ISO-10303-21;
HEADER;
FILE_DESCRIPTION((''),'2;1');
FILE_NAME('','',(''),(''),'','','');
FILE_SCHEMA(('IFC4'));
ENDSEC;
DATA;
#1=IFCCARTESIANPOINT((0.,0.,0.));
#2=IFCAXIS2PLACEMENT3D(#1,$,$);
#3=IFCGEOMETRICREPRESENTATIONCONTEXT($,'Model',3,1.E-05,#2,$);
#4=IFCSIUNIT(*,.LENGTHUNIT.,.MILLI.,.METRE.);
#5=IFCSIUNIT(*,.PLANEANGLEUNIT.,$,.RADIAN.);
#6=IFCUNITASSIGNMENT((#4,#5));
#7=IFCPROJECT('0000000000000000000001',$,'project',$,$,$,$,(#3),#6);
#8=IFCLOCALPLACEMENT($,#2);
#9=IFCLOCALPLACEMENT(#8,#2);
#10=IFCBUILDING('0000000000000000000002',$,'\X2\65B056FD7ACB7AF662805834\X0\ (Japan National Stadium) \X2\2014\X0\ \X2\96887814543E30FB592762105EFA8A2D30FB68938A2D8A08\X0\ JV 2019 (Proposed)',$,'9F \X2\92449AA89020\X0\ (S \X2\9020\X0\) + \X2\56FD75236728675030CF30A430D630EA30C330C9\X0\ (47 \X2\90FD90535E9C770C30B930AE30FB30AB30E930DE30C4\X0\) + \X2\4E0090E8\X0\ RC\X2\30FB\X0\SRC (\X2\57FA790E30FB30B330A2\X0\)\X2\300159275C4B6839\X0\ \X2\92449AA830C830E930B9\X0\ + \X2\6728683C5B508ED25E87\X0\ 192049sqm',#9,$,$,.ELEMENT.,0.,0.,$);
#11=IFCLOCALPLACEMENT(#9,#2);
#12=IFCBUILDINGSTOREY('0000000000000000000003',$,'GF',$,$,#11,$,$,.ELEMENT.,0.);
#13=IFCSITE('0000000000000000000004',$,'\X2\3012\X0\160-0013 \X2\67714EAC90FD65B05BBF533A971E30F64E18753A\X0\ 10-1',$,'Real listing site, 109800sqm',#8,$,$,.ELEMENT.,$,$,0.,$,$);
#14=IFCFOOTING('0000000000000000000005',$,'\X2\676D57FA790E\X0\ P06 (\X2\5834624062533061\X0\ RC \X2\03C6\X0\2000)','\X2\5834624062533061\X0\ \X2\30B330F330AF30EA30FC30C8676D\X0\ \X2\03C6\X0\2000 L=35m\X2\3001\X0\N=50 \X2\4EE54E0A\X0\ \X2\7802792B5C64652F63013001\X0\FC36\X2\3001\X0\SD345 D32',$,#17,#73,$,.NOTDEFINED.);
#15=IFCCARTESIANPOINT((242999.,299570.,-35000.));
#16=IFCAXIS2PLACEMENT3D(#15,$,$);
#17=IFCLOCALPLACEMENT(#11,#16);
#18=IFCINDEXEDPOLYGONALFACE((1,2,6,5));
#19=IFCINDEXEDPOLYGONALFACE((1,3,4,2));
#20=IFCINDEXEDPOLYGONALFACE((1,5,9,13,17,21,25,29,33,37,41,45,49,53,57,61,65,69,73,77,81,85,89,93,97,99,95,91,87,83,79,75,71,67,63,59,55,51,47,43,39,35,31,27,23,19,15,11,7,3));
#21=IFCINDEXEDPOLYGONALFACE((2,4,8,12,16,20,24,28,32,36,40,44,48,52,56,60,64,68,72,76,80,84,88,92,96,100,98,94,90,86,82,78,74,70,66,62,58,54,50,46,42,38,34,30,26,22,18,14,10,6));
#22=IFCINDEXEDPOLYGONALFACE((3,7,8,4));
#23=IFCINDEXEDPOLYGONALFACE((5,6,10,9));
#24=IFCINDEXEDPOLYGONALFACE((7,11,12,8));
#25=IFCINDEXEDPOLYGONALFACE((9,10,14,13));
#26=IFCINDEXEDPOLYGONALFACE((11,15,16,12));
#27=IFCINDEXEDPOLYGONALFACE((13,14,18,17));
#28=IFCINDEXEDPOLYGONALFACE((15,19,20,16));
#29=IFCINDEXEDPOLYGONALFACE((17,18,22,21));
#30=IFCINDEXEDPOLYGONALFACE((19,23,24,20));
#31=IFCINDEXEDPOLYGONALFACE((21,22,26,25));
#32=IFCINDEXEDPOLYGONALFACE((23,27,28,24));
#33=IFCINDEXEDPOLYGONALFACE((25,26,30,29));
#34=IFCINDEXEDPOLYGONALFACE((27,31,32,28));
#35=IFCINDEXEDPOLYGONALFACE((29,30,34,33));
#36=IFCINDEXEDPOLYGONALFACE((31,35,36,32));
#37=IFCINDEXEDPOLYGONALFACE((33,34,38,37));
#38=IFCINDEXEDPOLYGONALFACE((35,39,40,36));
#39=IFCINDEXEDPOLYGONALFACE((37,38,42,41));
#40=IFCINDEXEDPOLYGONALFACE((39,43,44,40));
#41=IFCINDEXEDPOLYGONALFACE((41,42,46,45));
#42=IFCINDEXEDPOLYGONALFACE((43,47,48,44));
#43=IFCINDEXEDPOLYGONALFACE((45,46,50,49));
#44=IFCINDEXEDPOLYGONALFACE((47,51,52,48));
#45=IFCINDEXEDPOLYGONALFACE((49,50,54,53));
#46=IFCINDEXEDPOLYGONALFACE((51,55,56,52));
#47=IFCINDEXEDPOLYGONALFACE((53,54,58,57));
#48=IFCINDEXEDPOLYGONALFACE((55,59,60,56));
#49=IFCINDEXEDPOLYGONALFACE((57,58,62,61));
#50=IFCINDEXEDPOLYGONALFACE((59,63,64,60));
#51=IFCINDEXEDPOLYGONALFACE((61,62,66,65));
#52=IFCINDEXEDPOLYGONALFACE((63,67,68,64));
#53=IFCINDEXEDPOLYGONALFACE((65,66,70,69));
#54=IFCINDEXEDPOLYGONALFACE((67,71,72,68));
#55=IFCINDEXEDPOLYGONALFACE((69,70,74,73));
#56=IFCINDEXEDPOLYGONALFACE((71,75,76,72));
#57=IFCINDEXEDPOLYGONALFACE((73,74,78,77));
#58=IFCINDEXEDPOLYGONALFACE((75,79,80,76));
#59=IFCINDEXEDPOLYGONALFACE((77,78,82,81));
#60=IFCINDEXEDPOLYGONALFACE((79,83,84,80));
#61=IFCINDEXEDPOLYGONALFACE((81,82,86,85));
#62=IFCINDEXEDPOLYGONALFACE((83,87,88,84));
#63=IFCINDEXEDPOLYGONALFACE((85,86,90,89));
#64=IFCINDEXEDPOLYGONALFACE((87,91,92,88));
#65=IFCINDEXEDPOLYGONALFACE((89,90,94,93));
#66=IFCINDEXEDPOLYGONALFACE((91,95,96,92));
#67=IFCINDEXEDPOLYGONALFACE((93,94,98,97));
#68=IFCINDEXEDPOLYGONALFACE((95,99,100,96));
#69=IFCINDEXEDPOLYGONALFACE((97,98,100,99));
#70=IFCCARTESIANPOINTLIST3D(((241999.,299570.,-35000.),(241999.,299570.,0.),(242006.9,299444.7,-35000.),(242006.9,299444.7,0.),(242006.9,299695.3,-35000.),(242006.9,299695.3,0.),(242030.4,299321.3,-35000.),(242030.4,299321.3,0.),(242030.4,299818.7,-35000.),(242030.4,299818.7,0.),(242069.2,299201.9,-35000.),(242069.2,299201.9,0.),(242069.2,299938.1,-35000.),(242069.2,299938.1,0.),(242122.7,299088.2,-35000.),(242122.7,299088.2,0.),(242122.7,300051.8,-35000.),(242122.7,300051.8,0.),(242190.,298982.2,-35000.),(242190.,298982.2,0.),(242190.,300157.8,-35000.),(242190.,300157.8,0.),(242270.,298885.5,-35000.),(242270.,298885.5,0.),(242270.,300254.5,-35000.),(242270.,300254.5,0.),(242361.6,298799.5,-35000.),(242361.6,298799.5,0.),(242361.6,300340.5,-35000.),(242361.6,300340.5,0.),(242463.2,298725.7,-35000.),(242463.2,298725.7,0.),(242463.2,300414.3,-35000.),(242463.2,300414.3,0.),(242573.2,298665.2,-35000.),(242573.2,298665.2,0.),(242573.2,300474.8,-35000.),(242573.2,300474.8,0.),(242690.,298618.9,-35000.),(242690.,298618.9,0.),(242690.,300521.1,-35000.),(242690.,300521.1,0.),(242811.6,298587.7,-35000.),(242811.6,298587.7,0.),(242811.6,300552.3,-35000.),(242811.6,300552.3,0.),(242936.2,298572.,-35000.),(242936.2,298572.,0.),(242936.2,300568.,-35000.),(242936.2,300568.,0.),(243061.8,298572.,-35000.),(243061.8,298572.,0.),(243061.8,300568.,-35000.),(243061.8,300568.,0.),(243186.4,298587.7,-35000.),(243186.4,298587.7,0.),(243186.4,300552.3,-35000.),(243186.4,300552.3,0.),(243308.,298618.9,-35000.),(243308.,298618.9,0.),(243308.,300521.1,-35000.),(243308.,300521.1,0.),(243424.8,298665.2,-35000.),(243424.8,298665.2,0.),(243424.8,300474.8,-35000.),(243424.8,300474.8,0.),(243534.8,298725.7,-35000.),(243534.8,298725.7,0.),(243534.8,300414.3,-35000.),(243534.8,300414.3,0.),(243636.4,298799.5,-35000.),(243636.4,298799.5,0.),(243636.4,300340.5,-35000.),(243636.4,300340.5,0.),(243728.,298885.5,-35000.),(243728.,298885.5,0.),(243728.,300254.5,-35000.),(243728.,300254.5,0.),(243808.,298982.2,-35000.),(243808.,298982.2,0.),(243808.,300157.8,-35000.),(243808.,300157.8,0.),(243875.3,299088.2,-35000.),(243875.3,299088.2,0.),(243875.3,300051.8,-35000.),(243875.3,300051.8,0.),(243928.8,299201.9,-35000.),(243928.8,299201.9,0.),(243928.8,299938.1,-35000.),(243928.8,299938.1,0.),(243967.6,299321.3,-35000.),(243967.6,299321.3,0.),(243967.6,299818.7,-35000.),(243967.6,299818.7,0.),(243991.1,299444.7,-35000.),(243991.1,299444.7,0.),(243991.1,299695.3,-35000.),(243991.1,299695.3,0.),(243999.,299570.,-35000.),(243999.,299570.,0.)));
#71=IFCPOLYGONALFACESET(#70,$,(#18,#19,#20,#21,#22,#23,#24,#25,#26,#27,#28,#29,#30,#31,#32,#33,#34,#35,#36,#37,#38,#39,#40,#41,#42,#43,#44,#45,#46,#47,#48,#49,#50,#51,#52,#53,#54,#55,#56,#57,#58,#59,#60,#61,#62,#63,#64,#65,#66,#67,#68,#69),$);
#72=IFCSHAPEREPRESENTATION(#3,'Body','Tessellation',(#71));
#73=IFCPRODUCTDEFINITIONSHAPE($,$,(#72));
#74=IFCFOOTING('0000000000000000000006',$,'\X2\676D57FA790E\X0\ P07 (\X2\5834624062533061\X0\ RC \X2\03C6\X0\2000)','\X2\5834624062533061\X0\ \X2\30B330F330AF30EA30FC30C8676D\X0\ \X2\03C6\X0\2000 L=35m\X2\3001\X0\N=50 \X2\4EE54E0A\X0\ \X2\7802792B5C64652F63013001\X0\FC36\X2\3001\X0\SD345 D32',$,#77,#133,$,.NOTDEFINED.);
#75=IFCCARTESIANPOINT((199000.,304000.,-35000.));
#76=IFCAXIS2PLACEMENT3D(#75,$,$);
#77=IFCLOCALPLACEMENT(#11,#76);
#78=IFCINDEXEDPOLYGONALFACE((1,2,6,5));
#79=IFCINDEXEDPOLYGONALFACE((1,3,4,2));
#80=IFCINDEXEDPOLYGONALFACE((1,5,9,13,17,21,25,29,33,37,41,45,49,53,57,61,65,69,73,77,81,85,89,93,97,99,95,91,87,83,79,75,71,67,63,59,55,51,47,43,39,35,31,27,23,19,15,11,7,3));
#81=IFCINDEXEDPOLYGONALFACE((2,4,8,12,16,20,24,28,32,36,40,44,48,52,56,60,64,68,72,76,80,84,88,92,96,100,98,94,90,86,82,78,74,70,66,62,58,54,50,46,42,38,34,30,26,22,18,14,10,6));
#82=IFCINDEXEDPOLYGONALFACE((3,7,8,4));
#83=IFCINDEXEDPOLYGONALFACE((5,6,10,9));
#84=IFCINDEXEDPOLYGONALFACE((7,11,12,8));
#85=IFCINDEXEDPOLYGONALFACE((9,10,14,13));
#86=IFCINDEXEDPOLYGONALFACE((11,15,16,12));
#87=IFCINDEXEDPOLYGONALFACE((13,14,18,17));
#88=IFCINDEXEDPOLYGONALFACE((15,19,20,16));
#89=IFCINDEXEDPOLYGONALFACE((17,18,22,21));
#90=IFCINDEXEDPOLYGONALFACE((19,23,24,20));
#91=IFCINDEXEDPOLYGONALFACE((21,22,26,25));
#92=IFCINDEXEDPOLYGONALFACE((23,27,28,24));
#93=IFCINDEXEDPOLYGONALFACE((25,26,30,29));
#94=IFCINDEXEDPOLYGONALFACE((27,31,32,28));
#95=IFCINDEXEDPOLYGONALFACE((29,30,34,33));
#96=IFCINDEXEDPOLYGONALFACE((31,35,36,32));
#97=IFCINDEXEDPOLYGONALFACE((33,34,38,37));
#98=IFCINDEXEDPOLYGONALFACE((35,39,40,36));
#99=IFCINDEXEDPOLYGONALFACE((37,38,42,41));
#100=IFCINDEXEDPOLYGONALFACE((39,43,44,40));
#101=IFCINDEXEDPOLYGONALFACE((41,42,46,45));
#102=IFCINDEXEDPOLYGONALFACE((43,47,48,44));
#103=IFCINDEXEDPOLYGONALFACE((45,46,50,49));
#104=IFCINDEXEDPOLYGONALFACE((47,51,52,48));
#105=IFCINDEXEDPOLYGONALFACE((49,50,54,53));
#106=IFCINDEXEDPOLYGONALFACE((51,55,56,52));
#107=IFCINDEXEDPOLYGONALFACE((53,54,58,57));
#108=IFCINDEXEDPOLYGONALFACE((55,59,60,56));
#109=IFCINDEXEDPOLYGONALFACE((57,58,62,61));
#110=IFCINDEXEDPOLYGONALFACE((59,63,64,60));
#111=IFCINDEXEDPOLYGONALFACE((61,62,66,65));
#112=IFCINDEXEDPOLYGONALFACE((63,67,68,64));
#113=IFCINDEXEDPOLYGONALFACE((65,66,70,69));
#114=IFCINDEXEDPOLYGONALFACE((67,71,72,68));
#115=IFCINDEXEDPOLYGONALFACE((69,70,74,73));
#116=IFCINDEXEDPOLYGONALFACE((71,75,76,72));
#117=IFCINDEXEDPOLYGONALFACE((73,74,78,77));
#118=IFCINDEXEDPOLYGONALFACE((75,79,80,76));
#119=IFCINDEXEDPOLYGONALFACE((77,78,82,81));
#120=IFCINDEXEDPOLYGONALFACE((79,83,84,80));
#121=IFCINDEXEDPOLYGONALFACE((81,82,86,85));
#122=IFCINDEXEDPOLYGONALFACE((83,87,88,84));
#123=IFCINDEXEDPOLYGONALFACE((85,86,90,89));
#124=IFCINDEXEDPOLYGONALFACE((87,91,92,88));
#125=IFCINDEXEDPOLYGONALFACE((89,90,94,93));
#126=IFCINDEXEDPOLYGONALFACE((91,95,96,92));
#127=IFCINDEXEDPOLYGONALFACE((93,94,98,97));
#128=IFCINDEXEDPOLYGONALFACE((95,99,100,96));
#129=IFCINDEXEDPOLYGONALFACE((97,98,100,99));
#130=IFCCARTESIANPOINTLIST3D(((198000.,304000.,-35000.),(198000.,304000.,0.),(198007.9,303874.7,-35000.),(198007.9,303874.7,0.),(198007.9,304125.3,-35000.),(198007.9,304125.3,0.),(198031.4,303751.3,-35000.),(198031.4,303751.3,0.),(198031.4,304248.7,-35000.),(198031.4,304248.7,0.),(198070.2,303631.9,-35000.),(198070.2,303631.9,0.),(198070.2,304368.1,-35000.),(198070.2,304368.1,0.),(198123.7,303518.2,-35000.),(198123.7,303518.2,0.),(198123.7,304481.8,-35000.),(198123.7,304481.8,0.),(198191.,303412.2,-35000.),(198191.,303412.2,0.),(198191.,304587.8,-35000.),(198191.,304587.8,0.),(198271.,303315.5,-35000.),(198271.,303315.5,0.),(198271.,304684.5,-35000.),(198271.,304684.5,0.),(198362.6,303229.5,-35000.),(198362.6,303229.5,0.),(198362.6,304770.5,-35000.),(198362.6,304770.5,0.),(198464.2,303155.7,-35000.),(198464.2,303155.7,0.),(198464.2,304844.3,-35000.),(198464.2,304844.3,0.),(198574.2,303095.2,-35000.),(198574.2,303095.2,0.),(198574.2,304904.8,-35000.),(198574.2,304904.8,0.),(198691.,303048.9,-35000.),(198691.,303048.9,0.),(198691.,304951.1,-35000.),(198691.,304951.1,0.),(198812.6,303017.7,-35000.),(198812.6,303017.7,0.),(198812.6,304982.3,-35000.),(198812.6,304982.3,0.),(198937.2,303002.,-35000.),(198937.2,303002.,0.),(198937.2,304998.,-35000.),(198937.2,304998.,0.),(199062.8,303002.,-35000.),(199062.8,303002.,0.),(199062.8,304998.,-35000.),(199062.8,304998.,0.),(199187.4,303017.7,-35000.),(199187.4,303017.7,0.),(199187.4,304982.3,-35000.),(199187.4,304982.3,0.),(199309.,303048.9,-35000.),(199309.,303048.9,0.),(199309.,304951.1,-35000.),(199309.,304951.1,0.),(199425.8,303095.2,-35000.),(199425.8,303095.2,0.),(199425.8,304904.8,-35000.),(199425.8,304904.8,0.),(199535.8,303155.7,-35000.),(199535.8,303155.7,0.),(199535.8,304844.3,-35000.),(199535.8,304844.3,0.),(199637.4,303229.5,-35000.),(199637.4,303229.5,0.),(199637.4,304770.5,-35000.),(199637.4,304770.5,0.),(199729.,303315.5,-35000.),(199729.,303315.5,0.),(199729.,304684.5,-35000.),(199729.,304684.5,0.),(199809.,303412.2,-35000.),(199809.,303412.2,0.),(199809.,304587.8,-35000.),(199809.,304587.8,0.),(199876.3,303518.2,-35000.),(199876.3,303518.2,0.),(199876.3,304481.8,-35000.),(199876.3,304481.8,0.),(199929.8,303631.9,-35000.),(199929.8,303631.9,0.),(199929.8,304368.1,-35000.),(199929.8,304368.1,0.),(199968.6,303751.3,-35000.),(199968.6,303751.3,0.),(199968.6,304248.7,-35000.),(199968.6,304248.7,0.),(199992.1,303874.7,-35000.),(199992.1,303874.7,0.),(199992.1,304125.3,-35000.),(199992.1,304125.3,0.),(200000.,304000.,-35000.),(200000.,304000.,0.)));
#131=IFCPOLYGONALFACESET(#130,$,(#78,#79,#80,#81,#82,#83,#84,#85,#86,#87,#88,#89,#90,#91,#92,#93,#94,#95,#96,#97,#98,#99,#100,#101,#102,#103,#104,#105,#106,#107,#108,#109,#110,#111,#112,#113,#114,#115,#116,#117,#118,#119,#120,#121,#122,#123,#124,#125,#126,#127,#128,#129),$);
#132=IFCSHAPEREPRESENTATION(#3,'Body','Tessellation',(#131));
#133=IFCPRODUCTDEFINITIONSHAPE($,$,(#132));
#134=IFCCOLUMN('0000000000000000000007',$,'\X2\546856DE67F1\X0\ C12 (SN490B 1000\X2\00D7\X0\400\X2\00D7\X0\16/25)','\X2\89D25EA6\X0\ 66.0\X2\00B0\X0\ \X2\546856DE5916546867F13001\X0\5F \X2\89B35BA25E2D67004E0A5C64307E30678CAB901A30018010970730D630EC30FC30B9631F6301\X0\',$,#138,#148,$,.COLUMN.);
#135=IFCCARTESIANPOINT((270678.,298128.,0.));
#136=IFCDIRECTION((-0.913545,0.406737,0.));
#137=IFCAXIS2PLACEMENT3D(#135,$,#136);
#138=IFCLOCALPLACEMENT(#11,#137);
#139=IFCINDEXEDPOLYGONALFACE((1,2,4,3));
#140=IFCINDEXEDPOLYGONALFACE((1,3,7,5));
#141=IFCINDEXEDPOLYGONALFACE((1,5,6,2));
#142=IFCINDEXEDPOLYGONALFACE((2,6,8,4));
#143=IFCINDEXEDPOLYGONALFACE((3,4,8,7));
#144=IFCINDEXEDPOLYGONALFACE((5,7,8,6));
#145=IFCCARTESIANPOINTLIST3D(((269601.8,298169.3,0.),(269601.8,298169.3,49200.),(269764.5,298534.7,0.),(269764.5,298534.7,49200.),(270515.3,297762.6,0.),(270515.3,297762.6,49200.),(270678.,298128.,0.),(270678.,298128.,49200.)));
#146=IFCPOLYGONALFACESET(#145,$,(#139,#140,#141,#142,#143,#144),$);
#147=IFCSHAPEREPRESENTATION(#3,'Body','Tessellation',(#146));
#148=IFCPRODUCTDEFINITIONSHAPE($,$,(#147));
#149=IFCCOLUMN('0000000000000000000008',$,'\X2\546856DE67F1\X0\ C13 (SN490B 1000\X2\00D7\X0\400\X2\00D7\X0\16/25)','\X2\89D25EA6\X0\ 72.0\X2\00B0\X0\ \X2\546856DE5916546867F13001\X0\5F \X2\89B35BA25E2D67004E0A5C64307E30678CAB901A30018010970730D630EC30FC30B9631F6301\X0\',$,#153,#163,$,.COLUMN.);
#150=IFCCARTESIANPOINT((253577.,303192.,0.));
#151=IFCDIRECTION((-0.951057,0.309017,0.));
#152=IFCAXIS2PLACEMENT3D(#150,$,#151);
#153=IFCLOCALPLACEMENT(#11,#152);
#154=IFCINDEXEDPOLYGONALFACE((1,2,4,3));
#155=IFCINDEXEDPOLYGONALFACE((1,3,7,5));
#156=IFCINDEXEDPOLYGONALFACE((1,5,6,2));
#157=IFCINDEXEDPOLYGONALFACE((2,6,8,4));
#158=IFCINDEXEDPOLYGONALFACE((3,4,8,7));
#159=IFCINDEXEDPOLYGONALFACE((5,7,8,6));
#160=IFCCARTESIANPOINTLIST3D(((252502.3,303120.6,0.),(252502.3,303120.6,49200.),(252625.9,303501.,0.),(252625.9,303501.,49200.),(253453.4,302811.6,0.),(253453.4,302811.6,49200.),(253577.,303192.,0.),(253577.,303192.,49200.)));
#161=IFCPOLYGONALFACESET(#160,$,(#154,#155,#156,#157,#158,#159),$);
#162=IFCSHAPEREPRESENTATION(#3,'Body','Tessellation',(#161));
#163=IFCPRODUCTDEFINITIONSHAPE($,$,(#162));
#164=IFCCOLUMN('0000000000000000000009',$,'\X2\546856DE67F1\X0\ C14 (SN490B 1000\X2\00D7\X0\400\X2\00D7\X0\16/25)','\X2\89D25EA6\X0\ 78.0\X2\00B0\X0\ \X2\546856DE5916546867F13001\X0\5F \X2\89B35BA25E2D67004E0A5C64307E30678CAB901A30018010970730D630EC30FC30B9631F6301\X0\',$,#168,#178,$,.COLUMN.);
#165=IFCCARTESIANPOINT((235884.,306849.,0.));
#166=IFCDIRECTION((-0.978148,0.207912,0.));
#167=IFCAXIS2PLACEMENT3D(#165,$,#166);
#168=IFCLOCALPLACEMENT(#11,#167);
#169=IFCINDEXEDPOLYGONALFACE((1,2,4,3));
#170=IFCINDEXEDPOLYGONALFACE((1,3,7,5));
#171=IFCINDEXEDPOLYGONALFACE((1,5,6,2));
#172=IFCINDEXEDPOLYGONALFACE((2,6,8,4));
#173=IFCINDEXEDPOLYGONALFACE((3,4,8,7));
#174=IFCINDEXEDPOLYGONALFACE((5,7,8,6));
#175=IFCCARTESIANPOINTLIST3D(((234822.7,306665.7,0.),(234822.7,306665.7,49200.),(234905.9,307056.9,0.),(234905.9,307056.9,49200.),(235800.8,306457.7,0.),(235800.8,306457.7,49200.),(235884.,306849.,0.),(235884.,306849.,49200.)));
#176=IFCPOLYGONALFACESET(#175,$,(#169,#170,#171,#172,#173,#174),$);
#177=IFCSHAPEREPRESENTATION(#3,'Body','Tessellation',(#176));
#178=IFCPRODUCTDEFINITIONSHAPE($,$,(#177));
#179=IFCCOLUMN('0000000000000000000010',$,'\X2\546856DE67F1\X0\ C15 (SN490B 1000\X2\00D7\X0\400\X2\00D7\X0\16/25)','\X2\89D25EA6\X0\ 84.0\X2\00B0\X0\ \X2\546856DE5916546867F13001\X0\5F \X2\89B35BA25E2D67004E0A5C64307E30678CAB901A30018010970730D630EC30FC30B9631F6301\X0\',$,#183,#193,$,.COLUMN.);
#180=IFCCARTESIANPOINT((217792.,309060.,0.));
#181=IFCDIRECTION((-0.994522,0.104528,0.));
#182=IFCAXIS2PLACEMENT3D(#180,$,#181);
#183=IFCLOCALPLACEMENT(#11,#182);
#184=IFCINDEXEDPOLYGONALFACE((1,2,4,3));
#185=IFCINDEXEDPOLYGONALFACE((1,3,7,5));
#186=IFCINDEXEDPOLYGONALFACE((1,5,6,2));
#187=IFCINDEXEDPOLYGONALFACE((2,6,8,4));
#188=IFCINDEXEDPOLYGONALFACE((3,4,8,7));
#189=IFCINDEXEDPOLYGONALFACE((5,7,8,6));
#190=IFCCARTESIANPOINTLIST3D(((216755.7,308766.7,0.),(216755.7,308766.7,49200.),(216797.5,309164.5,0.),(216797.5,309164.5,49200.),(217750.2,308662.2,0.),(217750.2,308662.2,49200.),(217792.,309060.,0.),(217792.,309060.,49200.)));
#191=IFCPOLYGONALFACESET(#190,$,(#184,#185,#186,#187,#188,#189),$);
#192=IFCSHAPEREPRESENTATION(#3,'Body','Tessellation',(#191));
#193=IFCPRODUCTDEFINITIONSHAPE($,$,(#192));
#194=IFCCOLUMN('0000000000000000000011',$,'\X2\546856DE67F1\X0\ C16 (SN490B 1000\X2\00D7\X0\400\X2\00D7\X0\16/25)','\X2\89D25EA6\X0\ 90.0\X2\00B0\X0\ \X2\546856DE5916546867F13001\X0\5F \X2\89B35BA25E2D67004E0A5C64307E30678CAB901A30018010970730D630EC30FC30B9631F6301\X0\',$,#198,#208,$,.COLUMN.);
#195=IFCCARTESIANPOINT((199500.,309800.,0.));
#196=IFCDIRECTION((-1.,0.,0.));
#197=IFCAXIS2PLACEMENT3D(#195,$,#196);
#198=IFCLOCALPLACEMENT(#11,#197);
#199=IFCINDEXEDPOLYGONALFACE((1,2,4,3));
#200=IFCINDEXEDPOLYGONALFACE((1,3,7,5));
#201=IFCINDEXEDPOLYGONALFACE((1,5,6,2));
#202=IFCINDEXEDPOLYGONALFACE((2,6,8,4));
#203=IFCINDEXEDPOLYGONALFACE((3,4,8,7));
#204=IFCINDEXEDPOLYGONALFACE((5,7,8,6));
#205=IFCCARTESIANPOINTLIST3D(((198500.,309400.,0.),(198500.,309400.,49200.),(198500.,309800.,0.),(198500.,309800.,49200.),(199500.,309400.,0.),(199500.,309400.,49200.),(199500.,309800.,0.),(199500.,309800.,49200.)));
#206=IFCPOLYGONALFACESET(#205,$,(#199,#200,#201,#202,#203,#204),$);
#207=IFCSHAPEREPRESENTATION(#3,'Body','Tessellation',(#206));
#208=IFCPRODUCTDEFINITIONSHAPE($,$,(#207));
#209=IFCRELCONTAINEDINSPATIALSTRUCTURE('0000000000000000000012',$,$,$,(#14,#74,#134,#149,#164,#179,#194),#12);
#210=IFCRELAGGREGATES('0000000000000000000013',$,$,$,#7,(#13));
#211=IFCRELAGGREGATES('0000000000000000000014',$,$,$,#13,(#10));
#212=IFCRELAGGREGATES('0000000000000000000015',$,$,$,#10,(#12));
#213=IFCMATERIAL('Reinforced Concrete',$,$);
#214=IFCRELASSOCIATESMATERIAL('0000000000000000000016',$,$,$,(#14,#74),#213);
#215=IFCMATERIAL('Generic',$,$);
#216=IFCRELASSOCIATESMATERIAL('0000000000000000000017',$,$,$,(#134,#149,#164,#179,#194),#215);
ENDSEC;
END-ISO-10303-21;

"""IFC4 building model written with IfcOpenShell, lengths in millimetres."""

from ifc_helpers import new_model, si_unit, frame, frame_2d, origin, origin_2d, place, context, project, spatial, rectangle, circle, extrude, material, element, save


model = new_model("IFC4")

# Units and contexts
model_context = context("Model", 3, precision=1e-05, world=origin())
ifc_project = project(units=[si_unit("LENGTHUNIT", "METRE", prefix="MILLI"), si_unit("PLANEANGLEUNIT", "RADIAN")], contexts=[model_context])

# Site, building, storey
site_placement = place(None, origin())
site = spatial("IfcSite", under=ifc_project, at=site_placement, Name="〒160-0013 東京都新宿区霞ヶ丘町 10-1", ObjectType="Real listing site, 109800sqm", CompositionType="ELEMENT", RefElevation=0.0)
building_placement = place(site_placement, origin())
building = spatial("IfcBuilding", under=site, at=building_placement, Name="新国立競技場 (Japan National Stadium) — 隈研吾・大成建設・梓設計 JV 2019 (Proposed)", ObjectType="9F 鉄骨造 (S 造) + 国産木材ハイブリッド (47 都道府県スギ・カラマツ) + 一部 RC・SRC (基礎・コア)、大屋根 鉄骨トラス + 木格子軒庇 192049sqm", CompositionType="ELEMENT", ElevationOfRefHeight=0.0, ElevationOfTerrain=0.0)
storey_placement = place(building_placement, origin())
storey = spatial("IfcBuildingStorey", under=building, at=storey_placement, Name="GF", CompositionType="ELEMENT", Elevation=0.0)

# Footings
ifc_material_1 = material(Name="Reinforced Concrete")
footing_1_placement = place(storey_placement, frame((242999.0, 299570.0, -35000.0)))
element("IfcFooting", 1, at=footing_1_placement, inside=storey, material=ifc_material_1, Name="杭基礎 P06 (場所打ち RC φ2000)", Description="場所打ち コンクリート杭 φ2000 L=35m、N=50 以上 砂礫層支持、FC36、SD345 D32", PredefinedType="NOTDEFINED", context=model_context, shape_type="SweptSolid", body=[
    extrude(circle(Radius=1000.0, at=origin_2d()), frame((242999.0, 299570.0, -35000.0)), (0.0, 0.0, 1.0), 35000.0),
])
footing_2_placement = place(storey_placement, frame((199000.0, 304000.0, -35000.0)))
element("IfcFooting", 2, at=footing_2_placement, inside=storey, material=ifc_material_1, Name="杭基礎 P07 (場所打ち RC φ2000)", Description="場所打ち コンクリート杭 φ2000 L=35m、N=50 以上 砂礫層支持、FC36、SD345 D32", PredefinedType="NOTDEFINED", context=model_context, shape_type="SweptSolid", body=[
    extrude(circle(Radius=1000.0, at=origin_2d()), frame((199000.0, 304000.0, -35000.0)), (0.0, 0.0, 1.0), 35000.0),
])

# Columns
ifc_material_2 = material(Name="Generic")
column_1_placement = place(storey_placement, frame((270678.0, 298128.0, 0.0), x_axis=(-0.913545, 0.406737, 0.0)))
element("IfcColumn", 3, at=column_1_placement, inside=storey, material=ifc_material_2, Name="周回柱 C12 (SN490B 1000×400×16/25)", Description="角度 66.0° 周回外周柱、5F 観客席最上層まで貫通、耐震ブレース挟持", PredefinedType="COLUMN", context=model_context, shape_type="SweptSolid", body=[
    extrude(rectangle(XDim=1000.0, YDim=400.0, at=frame_2d((500.0, 200.0))), frame((270678.0, 298128.0, 0.0), x_axis=(-0.913545, 0.406737, 0.0)), (0.0, 0.0, 1.0), 49200.0),
])
column_2_placement = place(storey_placement, frame((253577.0, 303192.0, 0.0), x_axis=(-0.951057, 0.309017, 0.0)))
element("IfcColumn", 4, at=column_2_placement, inside=storey, material=ifc_material_2, Name="周回柱 C13 (SN490B 1000×400×16/25)", Description="角度 72.0° 周回外周柱、5F 観客席最上層まで貫通、耐震ブレース挟持", PredefinedType="COLUMN", context=model_context, shape_type="SweptSolid", body=[
    extrude(rectangle(XDim=1000.0, YDim=400.0, at=frame_2d((500.0, 200.0))), frame((253577.0, 303192.0, 0.0), x_axis=(-0.951057, 0.309017, 0.0)), (0.0, 0.0, 1.0), 49200.0),
])
column_3_placement = place(storey_placement, frame((235884.0, 306849.0, 0.0), x_axis=(-0.978148, 0.207912, 0.0)))
element("IfcColumn", 5, at=column_3_placement, inside=storey, material=ifc_material_2, Name="周回柱 C14 (SN490B 1000×400×16/25)", Description="角度 78.0° 周回外周柱、5F 観客席最上層まで貫通、耐震ブレース挟持", PredefinedType="COLUMN", context=model_context, shape_type="SweptSolid", body=[
    extrude(rectangle(XDim=1000.0, YDim=400.0, at=frame_2d((500.0, 200.0))), frame((235884.0, 306849.0, 0.0), x_axis=(-0.978148, 0.207912, 0.0)), (0.0, 0.0, 1.0), 49200.0),
])
column_4_placement = place(storey_placement, frame((217792.0, 309060.0, 0.0), x_axis=(-0.994522, 0.104528, 0.0)))
element("IfcColumn", 6, at=column_4_placement, inside=storey, material=ifc_material_2, Name="周回柱 C15 (SN490B 1000×400×16/25)", Description="角度 84.0° 周回外周柱、5F 観客席最上層まで貫通、耐震ブレース挟持", PredefinedType="COLUMN", context=model_context, shape_type="SweptSolid", body=[
    extrude(rectangle(XDim=1000.0, YDim=400.0, at=frame_2d((500.0, 200.0))), frame((217792.0, 309060.0, 0.0), x_axis=(-0.994522, 0.104528, 0.0)), (0.0, 0.0, 1.0), 49200.0),
])
column_5_placement = place(storey_placement, frame((199500.0, 309800.0, 0.0), x_axis=(-1.0, 0.0, 0.0)))
element("IfcColumn", 7, at=column_5_placement, inside=storey, material=ifc_material_2, Name="周回柱 C16 (SN490B 1000×400×16/25)", Description="角度 90.0° 周回外周柱、5F 観客席最上層まで貫通、耐震ブレース挟持", PredefinedType="COLUMN", context=model_context, shape_type="SweptSolid", body=[
    extrude(rectangle(XDim=1000.0, YDim=400.0, at=frame_2d((500.0, 200.0))), frame((199500.0, 309800.0, 0.0), x_axis=(-1.0, 0.0, 0.0)), (0.0, 0.0, 1.0), 49200.0),
])

save(model, "model.ifc")
